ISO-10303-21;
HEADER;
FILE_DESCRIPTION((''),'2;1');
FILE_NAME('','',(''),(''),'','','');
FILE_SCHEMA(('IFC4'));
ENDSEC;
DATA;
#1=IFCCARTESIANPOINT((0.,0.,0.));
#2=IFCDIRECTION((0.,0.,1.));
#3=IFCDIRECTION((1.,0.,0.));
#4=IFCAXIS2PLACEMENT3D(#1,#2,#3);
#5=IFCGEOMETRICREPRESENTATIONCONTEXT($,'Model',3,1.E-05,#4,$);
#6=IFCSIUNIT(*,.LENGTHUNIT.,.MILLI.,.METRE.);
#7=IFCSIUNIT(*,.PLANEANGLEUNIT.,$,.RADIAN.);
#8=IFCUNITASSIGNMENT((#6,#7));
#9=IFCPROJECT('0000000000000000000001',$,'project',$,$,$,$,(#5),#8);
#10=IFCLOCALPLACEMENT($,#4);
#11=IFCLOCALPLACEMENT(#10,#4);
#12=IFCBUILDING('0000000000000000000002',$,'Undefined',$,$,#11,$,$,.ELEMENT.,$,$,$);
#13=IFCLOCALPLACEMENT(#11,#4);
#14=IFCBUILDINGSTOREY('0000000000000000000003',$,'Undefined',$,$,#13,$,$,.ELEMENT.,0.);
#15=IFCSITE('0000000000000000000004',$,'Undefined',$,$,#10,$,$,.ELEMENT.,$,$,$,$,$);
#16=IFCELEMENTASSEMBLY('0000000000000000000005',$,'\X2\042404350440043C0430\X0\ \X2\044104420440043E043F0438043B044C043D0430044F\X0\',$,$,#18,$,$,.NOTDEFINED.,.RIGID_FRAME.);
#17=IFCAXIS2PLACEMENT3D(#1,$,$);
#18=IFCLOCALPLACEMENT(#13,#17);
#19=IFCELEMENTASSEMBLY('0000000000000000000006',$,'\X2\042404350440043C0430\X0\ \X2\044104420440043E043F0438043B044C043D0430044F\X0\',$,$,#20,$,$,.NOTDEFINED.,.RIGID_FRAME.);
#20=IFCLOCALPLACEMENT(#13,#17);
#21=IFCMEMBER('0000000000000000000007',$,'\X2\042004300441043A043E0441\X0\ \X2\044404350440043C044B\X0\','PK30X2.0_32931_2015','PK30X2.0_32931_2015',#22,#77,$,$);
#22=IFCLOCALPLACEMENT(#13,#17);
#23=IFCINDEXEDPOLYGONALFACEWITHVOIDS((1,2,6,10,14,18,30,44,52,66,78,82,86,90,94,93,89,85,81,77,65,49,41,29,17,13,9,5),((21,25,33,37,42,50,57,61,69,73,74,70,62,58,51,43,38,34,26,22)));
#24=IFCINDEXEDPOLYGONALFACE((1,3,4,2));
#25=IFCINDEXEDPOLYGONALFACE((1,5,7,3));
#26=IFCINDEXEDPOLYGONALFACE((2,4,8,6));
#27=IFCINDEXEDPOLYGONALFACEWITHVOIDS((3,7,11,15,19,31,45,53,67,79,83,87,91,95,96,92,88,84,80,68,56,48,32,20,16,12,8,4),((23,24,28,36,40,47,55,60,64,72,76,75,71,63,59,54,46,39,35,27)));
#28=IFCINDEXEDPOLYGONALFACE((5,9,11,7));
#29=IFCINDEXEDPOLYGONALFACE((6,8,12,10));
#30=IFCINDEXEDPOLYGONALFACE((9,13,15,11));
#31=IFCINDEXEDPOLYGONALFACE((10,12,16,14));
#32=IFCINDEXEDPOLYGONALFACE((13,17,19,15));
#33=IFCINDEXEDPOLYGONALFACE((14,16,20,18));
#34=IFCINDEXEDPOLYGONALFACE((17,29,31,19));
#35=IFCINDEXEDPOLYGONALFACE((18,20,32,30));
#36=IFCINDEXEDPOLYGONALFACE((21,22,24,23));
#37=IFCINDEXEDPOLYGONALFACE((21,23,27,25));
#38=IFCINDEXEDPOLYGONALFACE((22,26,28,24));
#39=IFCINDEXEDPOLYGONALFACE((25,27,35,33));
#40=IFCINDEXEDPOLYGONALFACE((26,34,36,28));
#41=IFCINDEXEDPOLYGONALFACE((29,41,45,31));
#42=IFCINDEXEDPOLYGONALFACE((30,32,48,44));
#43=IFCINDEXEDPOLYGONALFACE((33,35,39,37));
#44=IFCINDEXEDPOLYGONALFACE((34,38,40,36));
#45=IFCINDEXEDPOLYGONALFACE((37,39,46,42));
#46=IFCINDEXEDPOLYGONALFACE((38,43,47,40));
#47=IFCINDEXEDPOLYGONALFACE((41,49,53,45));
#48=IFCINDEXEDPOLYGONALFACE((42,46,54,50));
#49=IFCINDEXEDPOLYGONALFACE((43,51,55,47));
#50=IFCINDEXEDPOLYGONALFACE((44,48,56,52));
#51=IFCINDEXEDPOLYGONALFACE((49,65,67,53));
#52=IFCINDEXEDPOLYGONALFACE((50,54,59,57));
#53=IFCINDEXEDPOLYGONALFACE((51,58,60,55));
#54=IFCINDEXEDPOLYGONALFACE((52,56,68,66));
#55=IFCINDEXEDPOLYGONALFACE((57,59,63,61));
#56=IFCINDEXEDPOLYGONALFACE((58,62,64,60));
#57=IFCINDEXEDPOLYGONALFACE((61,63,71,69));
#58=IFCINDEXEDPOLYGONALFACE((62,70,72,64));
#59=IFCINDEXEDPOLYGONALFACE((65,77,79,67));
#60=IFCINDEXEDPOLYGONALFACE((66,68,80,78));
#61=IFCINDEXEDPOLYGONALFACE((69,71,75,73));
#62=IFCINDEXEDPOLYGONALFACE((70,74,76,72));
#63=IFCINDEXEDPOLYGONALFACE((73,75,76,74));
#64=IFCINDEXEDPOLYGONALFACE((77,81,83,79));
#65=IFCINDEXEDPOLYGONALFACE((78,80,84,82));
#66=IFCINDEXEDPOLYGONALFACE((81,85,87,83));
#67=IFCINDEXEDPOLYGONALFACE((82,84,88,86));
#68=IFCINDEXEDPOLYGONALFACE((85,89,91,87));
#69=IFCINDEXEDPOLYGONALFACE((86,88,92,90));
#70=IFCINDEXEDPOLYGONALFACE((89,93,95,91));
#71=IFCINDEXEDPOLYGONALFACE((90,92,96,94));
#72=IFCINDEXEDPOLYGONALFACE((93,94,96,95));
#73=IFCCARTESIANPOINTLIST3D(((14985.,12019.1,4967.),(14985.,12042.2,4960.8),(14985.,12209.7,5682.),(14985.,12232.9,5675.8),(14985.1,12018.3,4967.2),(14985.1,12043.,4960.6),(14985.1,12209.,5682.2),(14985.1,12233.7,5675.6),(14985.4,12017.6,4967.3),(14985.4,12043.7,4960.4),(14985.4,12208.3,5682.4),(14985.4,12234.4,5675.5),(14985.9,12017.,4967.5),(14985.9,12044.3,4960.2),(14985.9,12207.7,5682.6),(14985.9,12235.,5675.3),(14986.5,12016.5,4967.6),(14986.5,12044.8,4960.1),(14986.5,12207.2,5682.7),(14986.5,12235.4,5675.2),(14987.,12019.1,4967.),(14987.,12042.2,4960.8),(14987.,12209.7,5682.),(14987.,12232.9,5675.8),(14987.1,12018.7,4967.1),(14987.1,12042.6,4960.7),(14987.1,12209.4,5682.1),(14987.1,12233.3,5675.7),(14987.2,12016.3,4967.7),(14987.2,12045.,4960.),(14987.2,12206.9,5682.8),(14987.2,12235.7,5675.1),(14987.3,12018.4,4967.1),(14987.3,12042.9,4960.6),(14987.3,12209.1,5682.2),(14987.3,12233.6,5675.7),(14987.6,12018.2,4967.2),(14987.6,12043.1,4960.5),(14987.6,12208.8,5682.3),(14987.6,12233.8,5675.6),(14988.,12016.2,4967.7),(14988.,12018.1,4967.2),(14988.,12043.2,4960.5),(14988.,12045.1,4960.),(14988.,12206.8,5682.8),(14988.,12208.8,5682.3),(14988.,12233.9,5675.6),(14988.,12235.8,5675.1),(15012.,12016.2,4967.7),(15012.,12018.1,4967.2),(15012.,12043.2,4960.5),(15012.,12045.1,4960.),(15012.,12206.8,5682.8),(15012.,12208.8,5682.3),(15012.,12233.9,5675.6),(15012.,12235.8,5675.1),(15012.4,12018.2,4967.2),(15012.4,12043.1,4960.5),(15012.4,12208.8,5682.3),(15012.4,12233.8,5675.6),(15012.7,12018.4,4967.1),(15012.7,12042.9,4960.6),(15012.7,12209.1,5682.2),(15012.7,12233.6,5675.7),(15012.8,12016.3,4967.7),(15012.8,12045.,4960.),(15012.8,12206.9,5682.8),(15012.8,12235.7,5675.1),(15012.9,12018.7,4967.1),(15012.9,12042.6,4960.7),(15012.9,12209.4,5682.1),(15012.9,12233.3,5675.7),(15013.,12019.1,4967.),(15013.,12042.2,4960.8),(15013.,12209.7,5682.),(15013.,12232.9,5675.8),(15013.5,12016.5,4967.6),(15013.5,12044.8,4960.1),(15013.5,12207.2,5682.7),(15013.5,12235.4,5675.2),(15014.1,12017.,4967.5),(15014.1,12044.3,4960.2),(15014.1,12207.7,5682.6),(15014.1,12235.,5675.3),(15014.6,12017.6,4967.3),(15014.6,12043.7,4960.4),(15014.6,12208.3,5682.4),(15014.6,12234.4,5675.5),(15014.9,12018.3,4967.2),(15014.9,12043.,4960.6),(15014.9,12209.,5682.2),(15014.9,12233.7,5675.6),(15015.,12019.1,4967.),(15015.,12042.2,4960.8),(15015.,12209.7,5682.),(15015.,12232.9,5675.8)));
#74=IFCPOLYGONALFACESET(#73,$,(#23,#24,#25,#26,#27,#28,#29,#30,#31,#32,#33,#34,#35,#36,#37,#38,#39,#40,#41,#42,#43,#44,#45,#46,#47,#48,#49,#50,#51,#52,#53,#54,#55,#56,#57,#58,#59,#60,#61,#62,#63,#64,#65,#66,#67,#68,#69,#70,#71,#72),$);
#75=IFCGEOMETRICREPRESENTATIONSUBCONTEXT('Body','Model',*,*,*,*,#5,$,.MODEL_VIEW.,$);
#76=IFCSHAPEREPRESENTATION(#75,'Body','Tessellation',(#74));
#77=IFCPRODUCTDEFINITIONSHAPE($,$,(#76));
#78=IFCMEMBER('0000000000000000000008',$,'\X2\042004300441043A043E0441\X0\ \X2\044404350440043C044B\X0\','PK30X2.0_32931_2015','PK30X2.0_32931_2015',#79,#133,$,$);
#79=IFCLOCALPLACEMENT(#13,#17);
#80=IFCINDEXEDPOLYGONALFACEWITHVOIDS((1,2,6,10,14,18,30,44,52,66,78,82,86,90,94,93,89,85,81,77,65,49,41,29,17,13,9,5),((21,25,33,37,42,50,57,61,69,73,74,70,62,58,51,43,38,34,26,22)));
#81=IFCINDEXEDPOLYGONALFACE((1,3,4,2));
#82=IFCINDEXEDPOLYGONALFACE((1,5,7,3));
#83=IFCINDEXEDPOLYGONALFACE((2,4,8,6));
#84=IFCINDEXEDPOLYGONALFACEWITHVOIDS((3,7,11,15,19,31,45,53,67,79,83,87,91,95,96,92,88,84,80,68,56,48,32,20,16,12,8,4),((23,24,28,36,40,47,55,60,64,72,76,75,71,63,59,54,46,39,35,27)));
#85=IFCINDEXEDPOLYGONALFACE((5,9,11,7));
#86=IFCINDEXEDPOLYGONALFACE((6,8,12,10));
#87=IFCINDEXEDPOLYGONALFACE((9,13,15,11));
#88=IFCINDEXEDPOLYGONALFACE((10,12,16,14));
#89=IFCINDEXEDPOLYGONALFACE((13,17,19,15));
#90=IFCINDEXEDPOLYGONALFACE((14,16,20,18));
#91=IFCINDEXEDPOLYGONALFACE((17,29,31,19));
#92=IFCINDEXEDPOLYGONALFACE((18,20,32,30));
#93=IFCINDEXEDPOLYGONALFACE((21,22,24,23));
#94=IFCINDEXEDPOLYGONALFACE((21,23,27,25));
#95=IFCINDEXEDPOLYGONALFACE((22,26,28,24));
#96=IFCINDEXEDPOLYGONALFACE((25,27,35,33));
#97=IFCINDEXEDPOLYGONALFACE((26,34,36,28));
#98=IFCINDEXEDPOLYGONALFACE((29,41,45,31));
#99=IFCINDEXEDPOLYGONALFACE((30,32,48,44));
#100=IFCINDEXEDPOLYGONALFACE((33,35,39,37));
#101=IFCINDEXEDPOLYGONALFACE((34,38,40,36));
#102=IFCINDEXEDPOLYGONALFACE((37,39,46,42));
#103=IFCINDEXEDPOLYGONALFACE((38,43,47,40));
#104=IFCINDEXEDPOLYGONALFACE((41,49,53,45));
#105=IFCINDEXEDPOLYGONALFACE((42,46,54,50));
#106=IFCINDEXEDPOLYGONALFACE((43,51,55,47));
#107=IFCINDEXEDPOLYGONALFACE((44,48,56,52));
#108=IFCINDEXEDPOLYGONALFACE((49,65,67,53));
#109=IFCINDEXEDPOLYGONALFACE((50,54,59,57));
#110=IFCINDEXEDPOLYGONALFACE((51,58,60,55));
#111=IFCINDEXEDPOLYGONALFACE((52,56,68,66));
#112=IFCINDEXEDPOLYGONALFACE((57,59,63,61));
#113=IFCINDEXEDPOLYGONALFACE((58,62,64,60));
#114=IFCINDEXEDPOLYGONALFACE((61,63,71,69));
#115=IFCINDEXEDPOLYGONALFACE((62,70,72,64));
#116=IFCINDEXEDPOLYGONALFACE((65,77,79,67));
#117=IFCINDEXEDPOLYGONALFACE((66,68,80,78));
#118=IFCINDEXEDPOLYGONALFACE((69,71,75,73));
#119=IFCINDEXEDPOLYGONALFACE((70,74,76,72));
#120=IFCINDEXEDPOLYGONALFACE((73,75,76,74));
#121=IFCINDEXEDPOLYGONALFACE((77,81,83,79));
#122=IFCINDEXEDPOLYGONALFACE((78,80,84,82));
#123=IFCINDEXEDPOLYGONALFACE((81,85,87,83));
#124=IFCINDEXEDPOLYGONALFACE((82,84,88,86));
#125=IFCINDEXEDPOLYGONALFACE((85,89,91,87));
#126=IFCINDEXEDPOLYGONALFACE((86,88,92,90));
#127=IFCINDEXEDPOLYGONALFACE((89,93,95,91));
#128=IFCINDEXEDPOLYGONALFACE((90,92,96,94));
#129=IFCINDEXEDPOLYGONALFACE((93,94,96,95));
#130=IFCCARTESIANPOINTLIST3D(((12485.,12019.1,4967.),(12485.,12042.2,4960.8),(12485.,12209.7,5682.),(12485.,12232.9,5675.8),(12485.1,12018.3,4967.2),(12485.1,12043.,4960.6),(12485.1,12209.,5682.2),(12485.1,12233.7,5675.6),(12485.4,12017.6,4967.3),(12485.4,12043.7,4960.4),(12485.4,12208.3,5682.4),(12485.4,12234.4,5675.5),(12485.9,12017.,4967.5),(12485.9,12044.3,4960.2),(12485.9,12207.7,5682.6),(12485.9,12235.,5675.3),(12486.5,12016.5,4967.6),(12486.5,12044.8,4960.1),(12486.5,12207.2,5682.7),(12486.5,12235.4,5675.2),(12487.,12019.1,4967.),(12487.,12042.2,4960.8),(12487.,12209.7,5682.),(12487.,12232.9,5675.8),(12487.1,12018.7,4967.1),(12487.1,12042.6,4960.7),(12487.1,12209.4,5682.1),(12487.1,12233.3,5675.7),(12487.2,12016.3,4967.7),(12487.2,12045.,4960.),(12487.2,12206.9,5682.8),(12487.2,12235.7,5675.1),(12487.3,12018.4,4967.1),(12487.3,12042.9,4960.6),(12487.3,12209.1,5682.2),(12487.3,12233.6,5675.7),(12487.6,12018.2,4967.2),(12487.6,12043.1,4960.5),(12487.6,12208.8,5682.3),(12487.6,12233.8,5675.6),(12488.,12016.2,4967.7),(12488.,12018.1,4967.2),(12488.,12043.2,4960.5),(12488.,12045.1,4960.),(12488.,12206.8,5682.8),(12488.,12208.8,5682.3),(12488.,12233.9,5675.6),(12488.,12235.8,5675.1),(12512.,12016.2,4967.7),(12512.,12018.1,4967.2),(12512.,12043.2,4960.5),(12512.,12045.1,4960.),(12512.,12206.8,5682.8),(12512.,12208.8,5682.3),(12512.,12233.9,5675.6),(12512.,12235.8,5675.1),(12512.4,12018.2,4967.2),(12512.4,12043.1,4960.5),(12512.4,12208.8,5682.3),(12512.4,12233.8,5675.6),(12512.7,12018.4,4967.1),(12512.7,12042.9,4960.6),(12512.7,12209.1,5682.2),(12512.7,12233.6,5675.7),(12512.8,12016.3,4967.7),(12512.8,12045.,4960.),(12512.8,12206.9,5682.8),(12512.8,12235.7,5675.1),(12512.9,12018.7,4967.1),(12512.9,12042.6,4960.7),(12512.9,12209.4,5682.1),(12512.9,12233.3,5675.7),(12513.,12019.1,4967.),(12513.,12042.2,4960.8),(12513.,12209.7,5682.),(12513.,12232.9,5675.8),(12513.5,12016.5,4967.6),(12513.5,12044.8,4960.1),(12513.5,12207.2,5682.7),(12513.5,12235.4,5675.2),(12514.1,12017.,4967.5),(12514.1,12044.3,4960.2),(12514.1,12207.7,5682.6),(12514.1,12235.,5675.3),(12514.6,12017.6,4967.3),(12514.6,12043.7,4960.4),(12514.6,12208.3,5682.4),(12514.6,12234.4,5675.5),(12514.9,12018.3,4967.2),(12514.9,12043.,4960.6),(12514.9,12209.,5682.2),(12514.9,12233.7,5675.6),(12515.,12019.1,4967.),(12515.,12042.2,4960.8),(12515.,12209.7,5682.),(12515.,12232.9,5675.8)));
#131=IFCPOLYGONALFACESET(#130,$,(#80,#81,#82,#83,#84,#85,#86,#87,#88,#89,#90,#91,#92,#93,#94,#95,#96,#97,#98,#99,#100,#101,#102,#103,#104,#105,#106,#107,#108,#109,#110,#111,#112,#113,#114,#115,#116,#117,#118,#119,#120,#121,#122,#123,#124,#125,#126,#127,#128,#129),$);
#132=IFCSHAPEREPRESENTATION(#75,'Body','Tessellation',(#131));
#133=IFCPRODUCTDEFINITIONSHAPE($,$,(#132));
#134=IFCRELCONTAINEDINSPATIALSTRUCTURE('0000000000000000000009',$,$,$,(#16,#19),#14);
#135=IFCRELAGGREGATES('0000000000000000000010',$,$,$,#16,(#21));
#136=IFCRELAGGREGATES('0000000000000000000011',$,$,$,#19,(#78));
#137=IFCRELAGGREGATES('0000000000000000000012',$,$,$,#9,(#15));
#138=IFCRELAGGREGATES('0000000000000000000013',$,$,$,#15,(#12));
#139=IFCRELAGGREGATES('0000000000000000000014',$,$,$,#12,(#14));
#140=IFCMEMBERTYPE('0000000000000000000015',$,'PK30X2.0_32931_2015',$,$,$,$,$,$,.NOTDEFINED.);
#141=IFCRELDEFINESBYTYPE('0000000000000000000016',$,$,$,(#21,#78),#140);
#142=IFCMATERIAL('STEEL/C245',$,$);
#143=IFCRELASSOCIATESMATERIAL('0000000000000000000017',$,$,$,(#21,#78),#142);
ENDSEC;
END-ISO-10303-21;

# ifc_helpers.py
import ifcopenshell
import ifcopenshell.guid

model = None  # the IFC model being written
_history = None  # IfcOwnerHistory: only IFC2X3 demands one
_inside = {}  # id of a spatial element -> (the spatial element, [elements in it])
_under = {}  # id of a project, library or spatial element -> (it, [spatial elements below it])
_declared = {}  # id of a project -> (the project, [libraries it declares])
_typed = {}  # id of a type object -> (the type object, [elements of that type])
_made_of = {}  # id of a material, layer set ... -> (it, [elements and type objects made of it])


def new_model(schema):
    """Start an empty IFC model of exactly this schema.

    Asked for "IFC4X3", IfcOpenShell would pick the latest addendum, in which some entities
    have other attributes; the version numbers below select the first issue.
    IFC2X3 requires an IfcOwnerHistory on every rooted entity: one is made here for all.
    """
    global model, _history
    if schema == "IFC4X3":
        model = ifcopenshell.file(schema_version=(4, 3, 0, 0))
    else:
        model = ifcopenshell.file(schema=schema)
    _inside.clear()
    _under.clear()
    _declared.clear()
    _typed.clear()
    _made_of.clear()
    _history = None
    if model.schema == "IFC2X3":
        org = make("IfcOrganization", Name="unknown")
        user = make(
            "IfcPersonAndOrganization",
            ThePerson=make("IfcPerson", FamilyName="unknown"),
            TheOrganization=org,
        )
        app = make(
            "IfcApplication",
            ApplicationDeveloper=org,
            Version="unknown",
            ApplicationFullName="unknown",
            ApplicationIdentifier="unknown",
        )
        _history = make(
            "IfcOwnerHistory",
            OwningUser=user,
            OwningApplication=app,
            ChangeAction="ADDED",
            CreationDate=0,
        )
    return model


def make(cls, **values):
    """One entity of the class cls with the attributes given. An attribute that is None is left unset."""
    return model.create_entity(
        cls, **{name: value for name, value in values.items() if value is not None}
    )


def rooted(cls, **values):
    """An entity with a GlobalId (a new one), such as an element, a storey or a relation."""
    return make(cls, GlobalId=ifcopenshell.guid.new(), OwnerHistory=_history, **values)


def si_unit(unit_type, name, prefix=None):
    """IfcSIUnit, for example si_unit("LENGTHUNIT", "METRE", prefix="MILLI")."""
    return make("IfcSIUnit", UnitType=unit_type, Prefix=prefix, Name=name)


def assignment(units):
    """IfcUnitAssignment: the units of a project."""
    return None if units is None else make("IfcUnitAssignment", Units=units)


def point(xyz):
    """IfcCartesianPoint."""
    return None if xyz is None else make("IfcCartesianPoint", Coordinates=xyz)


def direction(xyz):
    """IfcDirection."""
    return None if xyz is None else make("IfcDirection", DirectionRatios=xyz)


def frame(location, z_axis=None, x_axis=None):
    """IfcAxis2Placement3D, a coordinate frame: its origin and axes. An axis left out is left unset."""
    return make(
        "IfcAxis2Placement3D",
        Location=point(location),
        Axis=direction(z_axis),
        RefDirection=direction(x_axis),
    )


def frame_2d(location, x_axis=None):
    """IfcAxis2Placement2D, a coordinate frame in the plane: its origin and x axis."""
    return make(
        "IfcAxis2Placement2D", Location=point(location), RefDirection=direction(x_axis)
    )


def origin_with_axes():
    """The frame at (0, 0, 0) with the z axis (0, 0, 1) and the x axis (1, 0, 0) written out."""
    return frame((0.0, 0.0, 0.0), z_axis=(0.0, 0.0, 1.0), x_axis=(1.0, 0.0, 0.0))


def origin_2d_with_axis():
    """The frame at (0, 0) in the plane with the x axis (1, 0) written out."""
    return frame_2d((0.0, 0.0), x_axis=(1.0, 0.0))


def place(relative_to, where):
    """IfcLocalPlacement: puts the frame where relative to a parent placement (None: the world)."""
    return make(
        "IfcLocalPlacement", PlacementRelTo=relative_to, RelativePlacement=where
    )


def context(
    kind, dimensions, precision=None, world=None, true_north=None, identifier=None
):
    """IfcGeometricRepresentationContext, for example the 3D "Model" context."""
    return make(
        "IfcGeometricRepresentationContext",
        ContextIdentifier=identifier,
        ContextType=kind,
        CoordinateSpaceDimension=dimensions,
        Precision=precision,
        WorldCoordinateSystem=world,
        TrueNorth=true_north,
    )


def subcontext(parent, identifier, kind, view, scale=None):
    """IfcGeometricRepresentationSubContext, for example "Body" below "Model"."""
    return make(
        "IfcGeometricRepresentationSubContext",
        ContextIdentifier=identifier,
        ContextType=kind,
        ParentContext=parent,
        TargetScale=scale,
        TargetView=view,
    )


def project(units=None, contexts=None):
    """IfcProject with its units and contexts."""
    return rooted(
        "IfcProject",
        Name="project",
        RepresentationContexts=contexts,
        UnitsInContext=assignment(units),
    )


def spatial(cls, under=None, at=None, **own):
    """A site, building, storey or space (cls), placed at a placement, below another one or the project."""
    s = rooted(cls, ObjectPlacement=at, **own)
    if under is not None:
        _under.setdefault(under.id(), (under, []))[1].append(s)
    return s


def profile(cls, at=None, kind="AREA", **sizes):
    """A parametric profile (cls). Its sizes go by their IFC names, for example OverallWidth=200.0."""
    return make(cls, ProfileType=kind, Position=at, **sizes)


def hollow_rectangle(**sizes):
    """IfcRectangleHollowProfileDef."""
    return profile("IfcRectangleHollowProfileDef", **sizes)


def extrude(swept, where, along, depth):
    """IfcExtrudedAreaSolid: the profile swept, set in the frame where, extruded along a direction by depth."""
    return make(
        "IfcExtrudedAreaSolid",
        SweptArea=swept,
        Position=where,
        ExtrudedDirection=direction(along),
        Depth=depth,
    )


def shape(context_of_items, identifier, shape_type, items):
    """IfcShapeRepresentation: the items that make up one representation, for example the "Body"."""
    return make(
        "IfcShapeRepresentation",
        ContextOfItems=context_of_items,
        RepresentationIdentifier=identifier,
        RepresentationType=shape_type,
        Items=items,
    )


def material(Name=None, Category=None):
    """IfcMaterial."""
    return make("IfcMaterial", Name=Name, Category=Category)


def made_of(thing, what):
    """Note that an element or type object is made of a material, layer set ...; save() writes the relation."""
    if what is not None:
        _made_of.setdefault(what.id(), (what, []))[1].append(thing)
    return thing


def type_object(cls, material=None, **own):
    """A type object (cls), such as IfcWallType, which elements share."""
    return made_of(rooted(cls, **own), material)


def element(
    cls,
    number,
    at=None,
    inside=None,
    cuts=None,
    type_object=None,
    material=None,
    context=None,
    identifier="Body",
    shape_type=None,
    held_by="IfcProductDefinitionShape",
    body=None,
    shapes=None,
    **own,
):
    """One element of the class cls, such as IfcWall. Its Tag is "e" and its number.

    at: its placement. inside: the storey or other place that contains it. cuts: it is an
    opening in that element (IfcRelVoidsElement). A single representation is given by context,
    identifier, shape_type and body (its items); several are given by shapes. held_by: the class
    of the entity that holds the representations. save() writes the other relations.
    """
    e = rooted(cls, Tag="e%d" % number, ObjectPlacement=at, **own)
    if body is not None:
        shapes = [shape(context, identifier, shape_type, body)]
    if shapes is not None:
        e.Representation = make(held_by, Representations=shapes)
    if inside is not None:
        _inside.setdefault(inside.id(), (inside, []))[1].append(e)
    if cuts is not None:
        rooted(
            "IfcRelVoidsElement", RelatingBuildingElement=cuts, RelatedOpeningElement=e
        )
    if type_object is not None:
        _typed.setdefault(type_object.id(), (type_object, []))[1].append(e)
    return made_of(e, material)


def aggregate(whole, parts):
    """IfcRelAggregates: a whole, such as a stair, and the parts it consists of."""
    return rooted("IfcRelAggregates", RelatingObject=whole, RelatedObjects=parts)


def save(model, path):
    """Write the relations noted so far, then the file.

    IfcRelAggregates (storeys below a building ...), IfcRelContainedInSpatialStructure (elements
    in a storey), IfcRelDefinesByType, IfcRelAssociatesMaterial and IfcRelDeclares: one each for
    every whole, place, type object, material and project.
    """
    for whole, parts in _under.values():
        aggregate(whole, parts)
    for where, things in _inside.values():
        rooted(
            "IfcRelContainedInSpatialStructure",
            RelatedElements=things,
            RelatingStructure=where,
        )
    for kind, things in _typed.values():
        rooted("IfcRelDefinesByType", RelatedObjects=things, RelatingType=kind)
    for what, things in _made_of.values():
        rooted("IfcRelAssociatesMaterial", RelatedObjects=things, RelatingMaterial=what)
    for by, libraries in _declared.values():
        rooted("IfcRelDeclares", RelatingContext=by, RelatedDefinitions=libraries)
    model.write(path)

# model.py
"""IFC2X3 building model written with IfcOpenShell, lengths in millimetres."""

from ifc_helpers import new_model, si_unit, frame, origin_with_axes, origin_2d_with_axis, place, context, subcontext, project, spatial, hollow_rectangle, extrude, material, type_object, element, aggregate, save


model = new_model("IFC2X3")

# Units and contexts
model_context = context("Model", 3, precision=1e-05, world=origin_with_axes())
body_context = subcontext(model_context, "Body", "Model", "MODEL_VIEW")
ifc_project = project(units=[si_unit("LENGTHUNIT", "METRE", prefix="MILLI"), si_unit("PLANEANGLEUNIT", "RADIAN")], contexts=[model_context])

# Site, building, storey
site_placement = place(None, origin_with_axes())
site = spatial("IfcSite", under=ifc_project, at=site_placement, Name="Undefined", CompositionType="ELEMENT")
building_placement = place(site_placement, origin_with_axes())
building = spatial("IfcBuilding", under=site, at=building_placement, Name="Undefined", CompositionType="ELEMENT")
storey_placement = place(building_placement, origin_with_axes())
storey = spatial("IfcBuildingStorey", under=building, at=storey_placement, Name="Undefined", CompositionType="ELEMENT", Elevation=0.0)

# Shared definitions
ifc_material_1 = material(Name="STEEL/C245")

# Element assembly
assembly_1_placement = place(storey_placement, origin_with_axes())
assembly_1 = element("IfcElementAssembly", 1, at=assembly_1_placement, inside=storey, Name="Ферма стропильная", AssemblyPlace="NOTDEFINED", PredefinedType="RIGID_FRAME")

# Element assembly
assembly_2_placement = place(storey_placement, origin_with_axes())
assembly_2 = element("IfcElementAssembly", 2, at=assembly_2_placement, inside=storey, Name="Ферма стропильная", AssemblyPlace="NOTDEFINED", PredefinedType="RIGID_FRAME")

# Members
member_type_1 = type_object("IfcMemberType", Name="PK30X2.0_32931_2015", PredefinedType="NOTDEFINED")
member_1_placement = place(assembly_1_placement, frame((15000.0, 12221.3, 5678.9), z_axis=(0.0, 0.966235, -0.257663), x_axis=(0.0, -0.257663, -0.966235)))
member_1 = element("IfcMember", 3, at=member_1_placement, type_object=member_type_1, material=ifc_material_1, Name="Раскос фермы", Description="PK30X2.0_32931_2015", ObjectType="PK30X2.0_32931_2015", context=body_context, shape_type="SweptSolid", body=[
    extrude(hollow_rectangle(XDim=30.0, YDim=30.0, WallThickness=2.0, InnerFilletRadius=1.0, OuterFilletRadius=3.0, at=origin_2d_with_axis()), frame((740.0, 0.0, 0.0), z_axis=(-1.0, 0.0, 0.0), x_axis=(0.0, -1.0, 0.0)), (0.0, 0.0, 1.0), 740.0),
])
aggregate(assembly_1, [member_1])
member_2_placement = place(assembly_2_placement, frame((12500.0, 12221.3, 5678.9), z_axis=(0.0, 0.966235, -0.257663), x_axis=(0.0, -0.257663, -0.966235)))
member_2 = element("IfcMember", 4, at=member_2_placement, type_object=member_type_1, material=ifc_material_1, Name="Раскос фермы", Description="PK30X2.0_32931_2015", ObjectType="PK30X2.0_32931_2015", context=body_context, shape_type="SweptSolid", body=[
    extrude(hollow_rectangle(XDim=30.0, YDim=30.0, WallThickness=2.0, InnerFilletRadius=1.0, OuterFilletRadius=3.0, at=origin_2d_with_axis()), frame((740.0, 0.0, 0.0), z_axis=(-1.0, 0.0, 0.0), x_axis=(0.0, -1.0, 0.0)), (0.0, 0.0, 1.0), 740.0),
])
aggregate(assembly_2, [member_2])

save(model, "model.ifc")
